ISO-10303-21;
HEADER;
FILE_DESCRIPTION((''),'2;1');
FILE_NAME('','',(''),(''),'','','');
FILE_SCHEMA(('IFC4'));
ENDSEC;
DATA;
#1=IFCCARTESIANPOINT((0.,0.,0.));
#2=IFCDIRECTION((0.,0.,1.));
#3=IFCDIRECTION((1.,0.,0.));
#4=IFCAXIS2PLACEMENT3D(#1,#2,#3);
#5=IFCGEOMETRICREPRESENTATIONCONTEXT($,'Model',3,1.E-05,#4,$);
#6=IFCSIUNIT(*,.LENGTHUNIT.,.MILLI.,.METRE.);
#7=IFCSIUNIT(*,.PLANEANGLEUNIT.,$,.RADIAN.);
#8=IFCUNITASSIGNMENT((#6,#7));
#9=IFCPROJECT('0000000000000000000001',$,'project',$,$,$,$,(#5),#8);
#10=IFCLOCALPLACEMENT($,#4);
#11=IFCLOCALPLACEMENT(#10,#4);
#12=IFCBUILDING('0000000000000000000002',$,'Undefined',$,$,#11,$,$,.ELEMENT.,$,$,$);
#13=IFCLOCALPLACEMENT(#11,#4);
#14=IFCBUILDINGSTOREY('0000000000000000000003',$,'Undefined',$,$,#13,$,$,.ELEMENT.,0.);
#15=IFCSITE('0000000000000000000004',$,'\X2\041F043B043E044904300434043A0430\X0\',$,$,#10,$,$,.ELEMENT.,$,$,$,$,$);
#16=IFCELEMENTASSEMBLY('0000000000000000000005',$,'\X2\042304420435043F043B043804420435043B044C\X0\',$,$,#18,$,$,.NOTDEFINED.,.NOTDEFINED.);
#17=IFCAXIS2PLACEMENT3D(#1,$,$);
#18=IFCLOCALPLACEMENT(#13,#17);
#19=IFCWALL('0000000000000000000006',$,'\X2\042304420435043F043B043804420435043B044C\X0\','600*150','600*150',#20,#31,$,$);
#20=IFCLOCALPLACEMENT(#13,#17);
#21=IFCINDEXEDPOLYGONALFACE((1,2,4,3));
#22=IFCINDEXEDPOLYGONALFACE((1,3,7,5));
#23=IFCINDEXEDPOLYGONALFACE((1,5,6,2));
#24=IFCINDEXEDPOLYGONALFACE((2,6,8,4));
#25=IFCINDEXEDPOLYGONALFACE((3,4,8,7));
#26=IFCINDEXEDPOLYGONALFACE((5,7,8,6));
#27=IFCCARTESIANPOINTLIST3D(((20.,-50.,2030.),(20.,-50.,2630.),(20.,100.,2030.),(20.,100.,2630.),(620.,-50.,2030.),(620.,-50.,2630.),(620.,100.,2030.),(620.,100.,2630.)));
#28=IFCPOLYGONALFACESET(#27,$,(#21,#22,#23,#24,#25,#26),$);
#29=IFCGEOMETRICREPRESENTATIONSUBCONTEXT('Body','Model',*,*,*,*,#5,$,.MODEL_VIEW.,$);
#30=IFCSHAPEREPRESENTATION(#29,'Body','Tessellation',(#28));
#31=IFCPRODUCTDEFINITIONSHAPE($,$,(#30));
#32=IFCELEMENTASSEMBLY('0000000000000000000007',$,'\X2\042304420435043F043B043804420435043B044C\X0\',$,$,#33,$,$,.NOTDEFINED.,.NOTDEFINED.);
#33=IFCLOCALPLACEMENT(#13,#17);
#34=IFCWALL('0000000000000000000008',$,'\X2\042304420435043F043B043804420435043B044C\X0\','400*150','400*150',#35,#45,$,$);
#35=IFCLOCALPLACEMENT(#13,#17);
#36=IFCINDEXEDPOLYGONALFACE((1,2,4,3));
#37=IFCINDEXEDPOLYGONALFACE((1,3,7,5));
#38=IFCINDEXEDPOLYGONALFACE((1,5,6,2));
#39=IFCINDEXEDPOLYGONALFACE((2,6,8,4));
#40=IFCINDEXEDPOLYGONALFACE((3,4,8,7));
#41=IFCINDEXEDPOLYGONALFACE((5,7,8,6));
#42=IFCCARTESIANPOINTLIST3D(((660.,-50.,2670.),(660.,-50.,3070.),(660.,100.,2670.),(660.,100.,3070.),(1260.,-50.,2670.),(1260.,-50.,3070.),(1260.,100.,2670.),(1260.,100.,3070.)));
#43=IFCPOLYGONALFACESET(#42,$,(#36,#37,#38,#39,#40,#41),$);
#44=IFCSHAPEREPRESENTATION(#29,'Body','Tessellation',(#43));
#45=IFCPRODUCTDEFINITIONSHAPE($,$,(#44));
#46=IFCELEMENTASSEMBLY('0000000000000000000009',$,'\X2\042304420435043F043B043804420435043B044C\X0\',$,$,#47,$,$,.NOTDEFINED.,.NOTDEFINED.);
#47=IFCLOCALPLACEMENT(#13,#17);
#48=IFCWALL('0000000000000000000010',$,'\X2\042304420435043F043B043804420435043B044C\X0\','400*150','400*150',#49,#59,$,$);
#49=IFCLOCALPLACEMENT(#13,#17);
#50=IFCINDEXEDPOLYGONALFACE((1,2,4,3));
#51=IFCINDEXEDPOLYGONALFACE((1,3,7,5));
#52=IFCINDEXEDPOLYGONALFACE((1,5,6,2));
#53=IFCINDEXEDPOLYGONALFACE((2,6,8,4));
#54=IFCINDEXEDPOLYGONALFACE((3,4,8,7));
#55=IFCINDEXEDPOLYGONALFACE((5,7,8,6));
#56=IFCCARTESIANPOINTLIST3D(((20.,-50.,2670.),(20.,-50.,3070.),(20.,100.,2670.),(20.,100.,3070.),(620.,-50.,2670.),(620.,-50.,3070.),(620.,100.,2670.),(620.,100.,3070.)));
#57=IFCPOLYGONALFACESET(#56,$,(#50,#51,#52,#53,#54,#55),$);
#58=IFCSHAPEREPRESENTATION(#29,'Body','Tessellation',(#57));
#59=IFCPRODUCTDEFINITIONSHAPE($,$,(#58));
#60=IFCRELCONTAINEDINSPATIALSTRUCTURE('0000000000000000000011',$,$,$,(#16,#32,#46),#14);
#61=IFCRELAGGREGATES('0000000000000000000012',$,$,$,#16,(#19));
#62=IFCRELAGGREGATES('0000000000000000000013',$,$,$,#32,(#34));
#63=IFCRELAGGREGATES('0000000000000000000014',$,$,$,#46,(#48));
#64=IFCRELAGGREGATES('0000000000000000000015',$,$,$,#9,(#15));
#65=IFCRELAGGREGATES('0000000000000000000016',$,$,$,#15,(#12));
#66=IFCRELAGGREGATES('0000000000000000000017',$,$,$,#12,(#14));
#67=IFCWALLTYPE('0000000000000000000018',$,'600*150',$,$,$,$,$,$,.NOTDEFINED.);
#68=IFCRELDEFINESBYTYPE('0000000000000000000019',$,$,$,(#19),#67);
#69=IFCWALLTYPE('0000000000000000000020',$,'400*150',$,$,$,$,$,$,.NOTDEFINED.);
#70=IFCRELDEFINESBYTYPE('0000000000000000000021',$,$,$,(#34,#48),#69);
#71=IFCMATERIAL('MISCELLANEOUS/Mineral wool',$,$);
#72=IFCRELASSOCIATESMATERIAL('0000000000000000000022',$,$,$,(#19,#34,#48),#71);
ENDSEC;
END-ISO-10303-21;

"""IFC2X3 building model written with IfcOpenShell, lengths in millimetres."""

from ifc_helpers import new_model, si_unit, frame, frame_2d, origin_with_axes, place, context, subcontext, project, spatial, rectangle, extrude, material, type_object, element, aggregate, save


model = new_model("IFC2X3")

# Units and contexts
model_context = context("Model", 3, precision=1e-05, world=origin_with_axes())
body_context = subcontext(model_context, "Body", "Model", "MODEL_VIEW")
ifc_project = project(units=[si_unit("LENGTHUNIT", "METRE", prefix="MILLI"), si_unit("PLANEANGLEUNIT", "RADIAN")], contexts=[model_context])

# Site, building, storey
site_placement = place(None, origin_with_axes())
site = spatial("IfcSite", under=ifc_project, at=site_placement, Name="Площадка", CompositionType="ELEMENT")
building_placement = place(site_placement, origin_with_axes())
building = spatial("IfcBuilding", under=site, at=building_placement, Name="Undefined", CompositionType="ELEMENT")
storey_placement = place(building_placement, origin_with_axes())
storey = spatial("IfcBuildingStorey", under=building, at=storey_placement, Name="Undefined", CompositionType="ELEMENT", Elevation=0.0)

# Element assemblies, walls
ifc_material_1 = material(Name="MISCELLANEOUS/Mineral wool")
wall_type_1 = type_object("IfcWallType", Name="600*150", PredefinedType="NOTDEFINED")
assembly_1_placement = place(storey_placement, origin_with_axes())
assembly_1 = element("IfcElementAssembly", 1, at=assembly_1_placement, inside=storey, Name="Утеплитель", AssemblyPlace="NOTDEFINED", PredefinedType="NOTDEFINED")
wall_1_placement = place(assembly_1_placement, frame((20.0, 25.0, 2030.0), z_axis=(0.0, 0.0, 1.0), x_axis=(1.0, 0.0, 0.0)))
wall_1 = element("IfcWall", 2, at=wall_1_placement, type_object=wall_type_1, material=ifc_material_1, Name="Утеплитель", Description="600*150", ObjectType="600*150", context=body_context, shape_type="SweptSolid", body=[
    extrude(rectangle(XDim=600.0, YDim=150.0, at=frame_2d((0.0, 300.0), x_axis=(0.0, -1.0))), frame((0.0, 0.0, 0.0), z_axis=(0.0, 0.0, 1.0), x_axis=(0.0, -1.0, 0.0)), (0.0, 0.0, 1.0), 600.0),
])
aggregate(assembly_1, [wall_1])
assembly_2_placement = place(storey_placement, origin_with_axes())
assembly_2 = element("IfcElementAssembly", 3, at=assembly_2_placement, inside=storey, Name="Утеплитель", AssemblyPlace="NOTDEFINED", PredefinedType="NOTDEFINED")
wall_type_2 = type_object("IfcWallType", Name="400*150", PredefinedType="NOTDEFINED")
wall_2_placement = place(assembly_2_placement, frame((660.0, 25.0, 2670.0), z_axis=(0.0, 0.0, 1.0), x_axis=(1.0, 0.0, 0.0)))
wall_2 = element("IfcWall", 4, at=wall_2_placement, type_object=wall_type_2, material=ifc_material_1, Name="Утеплитель", Description="400*150", ObjectType="400*150", context=body_context, shape_type="SweptSolid", body=[
    extrude(rectangle(XDim=600.0, YDim=150.0, at=frame_2d((0.0, 300.0), x_axis=(0.0, -1.0))), frame((0.0, 0.0, 0.0), z_axis=(0.0, 0.0, 1.0), x_axis=(0.0, -1.0, 0.0)), (0.0, 0.0, 1.0), 400.0),
])
aggregate(assembly_2, [wall_2])
assembly_3_placement = place(storey_placement, origin_with_axes())
assembly_3 = element("IfcElementAssembly", 5, at=assembly_3_placement, inside=storey, Name="Утеплитель", AssemblyPlace="NOTDEFINED", PredefinedType="NOTDEFINED")
wall_3_placement = place(assembly_3_placement, frame((20.0, 25.0, 2670.0), z_axis=(0.0, 0.0, 1.0), x_axis=(1.0, 0.0, 0.0)))
wall_3 = element("IfcWall", 6, at=wall_3_placement, type_object=wall_type_2, material=ifc_material_1, Name="Утеплитель", Description="400*150", ObjectType="400*150", context=body_context, shape_type="SweptSolid", body=[
    extrude(rectangle(XDim=600.0, YDim=150.0, at=frame_2d((0.0, 300.0), x_axis=(0.0, -1.0))), frame((0.0, 0.0, 0.0), z_axis=(0.0, 0.0, 1.0), x_axis=(0.0, -1.0, 0.0)), (0.0, 0.0, 1.0), 400.0),
])
aggregate(assembly_3, [wall_3])

save(model, "model.ifc")
